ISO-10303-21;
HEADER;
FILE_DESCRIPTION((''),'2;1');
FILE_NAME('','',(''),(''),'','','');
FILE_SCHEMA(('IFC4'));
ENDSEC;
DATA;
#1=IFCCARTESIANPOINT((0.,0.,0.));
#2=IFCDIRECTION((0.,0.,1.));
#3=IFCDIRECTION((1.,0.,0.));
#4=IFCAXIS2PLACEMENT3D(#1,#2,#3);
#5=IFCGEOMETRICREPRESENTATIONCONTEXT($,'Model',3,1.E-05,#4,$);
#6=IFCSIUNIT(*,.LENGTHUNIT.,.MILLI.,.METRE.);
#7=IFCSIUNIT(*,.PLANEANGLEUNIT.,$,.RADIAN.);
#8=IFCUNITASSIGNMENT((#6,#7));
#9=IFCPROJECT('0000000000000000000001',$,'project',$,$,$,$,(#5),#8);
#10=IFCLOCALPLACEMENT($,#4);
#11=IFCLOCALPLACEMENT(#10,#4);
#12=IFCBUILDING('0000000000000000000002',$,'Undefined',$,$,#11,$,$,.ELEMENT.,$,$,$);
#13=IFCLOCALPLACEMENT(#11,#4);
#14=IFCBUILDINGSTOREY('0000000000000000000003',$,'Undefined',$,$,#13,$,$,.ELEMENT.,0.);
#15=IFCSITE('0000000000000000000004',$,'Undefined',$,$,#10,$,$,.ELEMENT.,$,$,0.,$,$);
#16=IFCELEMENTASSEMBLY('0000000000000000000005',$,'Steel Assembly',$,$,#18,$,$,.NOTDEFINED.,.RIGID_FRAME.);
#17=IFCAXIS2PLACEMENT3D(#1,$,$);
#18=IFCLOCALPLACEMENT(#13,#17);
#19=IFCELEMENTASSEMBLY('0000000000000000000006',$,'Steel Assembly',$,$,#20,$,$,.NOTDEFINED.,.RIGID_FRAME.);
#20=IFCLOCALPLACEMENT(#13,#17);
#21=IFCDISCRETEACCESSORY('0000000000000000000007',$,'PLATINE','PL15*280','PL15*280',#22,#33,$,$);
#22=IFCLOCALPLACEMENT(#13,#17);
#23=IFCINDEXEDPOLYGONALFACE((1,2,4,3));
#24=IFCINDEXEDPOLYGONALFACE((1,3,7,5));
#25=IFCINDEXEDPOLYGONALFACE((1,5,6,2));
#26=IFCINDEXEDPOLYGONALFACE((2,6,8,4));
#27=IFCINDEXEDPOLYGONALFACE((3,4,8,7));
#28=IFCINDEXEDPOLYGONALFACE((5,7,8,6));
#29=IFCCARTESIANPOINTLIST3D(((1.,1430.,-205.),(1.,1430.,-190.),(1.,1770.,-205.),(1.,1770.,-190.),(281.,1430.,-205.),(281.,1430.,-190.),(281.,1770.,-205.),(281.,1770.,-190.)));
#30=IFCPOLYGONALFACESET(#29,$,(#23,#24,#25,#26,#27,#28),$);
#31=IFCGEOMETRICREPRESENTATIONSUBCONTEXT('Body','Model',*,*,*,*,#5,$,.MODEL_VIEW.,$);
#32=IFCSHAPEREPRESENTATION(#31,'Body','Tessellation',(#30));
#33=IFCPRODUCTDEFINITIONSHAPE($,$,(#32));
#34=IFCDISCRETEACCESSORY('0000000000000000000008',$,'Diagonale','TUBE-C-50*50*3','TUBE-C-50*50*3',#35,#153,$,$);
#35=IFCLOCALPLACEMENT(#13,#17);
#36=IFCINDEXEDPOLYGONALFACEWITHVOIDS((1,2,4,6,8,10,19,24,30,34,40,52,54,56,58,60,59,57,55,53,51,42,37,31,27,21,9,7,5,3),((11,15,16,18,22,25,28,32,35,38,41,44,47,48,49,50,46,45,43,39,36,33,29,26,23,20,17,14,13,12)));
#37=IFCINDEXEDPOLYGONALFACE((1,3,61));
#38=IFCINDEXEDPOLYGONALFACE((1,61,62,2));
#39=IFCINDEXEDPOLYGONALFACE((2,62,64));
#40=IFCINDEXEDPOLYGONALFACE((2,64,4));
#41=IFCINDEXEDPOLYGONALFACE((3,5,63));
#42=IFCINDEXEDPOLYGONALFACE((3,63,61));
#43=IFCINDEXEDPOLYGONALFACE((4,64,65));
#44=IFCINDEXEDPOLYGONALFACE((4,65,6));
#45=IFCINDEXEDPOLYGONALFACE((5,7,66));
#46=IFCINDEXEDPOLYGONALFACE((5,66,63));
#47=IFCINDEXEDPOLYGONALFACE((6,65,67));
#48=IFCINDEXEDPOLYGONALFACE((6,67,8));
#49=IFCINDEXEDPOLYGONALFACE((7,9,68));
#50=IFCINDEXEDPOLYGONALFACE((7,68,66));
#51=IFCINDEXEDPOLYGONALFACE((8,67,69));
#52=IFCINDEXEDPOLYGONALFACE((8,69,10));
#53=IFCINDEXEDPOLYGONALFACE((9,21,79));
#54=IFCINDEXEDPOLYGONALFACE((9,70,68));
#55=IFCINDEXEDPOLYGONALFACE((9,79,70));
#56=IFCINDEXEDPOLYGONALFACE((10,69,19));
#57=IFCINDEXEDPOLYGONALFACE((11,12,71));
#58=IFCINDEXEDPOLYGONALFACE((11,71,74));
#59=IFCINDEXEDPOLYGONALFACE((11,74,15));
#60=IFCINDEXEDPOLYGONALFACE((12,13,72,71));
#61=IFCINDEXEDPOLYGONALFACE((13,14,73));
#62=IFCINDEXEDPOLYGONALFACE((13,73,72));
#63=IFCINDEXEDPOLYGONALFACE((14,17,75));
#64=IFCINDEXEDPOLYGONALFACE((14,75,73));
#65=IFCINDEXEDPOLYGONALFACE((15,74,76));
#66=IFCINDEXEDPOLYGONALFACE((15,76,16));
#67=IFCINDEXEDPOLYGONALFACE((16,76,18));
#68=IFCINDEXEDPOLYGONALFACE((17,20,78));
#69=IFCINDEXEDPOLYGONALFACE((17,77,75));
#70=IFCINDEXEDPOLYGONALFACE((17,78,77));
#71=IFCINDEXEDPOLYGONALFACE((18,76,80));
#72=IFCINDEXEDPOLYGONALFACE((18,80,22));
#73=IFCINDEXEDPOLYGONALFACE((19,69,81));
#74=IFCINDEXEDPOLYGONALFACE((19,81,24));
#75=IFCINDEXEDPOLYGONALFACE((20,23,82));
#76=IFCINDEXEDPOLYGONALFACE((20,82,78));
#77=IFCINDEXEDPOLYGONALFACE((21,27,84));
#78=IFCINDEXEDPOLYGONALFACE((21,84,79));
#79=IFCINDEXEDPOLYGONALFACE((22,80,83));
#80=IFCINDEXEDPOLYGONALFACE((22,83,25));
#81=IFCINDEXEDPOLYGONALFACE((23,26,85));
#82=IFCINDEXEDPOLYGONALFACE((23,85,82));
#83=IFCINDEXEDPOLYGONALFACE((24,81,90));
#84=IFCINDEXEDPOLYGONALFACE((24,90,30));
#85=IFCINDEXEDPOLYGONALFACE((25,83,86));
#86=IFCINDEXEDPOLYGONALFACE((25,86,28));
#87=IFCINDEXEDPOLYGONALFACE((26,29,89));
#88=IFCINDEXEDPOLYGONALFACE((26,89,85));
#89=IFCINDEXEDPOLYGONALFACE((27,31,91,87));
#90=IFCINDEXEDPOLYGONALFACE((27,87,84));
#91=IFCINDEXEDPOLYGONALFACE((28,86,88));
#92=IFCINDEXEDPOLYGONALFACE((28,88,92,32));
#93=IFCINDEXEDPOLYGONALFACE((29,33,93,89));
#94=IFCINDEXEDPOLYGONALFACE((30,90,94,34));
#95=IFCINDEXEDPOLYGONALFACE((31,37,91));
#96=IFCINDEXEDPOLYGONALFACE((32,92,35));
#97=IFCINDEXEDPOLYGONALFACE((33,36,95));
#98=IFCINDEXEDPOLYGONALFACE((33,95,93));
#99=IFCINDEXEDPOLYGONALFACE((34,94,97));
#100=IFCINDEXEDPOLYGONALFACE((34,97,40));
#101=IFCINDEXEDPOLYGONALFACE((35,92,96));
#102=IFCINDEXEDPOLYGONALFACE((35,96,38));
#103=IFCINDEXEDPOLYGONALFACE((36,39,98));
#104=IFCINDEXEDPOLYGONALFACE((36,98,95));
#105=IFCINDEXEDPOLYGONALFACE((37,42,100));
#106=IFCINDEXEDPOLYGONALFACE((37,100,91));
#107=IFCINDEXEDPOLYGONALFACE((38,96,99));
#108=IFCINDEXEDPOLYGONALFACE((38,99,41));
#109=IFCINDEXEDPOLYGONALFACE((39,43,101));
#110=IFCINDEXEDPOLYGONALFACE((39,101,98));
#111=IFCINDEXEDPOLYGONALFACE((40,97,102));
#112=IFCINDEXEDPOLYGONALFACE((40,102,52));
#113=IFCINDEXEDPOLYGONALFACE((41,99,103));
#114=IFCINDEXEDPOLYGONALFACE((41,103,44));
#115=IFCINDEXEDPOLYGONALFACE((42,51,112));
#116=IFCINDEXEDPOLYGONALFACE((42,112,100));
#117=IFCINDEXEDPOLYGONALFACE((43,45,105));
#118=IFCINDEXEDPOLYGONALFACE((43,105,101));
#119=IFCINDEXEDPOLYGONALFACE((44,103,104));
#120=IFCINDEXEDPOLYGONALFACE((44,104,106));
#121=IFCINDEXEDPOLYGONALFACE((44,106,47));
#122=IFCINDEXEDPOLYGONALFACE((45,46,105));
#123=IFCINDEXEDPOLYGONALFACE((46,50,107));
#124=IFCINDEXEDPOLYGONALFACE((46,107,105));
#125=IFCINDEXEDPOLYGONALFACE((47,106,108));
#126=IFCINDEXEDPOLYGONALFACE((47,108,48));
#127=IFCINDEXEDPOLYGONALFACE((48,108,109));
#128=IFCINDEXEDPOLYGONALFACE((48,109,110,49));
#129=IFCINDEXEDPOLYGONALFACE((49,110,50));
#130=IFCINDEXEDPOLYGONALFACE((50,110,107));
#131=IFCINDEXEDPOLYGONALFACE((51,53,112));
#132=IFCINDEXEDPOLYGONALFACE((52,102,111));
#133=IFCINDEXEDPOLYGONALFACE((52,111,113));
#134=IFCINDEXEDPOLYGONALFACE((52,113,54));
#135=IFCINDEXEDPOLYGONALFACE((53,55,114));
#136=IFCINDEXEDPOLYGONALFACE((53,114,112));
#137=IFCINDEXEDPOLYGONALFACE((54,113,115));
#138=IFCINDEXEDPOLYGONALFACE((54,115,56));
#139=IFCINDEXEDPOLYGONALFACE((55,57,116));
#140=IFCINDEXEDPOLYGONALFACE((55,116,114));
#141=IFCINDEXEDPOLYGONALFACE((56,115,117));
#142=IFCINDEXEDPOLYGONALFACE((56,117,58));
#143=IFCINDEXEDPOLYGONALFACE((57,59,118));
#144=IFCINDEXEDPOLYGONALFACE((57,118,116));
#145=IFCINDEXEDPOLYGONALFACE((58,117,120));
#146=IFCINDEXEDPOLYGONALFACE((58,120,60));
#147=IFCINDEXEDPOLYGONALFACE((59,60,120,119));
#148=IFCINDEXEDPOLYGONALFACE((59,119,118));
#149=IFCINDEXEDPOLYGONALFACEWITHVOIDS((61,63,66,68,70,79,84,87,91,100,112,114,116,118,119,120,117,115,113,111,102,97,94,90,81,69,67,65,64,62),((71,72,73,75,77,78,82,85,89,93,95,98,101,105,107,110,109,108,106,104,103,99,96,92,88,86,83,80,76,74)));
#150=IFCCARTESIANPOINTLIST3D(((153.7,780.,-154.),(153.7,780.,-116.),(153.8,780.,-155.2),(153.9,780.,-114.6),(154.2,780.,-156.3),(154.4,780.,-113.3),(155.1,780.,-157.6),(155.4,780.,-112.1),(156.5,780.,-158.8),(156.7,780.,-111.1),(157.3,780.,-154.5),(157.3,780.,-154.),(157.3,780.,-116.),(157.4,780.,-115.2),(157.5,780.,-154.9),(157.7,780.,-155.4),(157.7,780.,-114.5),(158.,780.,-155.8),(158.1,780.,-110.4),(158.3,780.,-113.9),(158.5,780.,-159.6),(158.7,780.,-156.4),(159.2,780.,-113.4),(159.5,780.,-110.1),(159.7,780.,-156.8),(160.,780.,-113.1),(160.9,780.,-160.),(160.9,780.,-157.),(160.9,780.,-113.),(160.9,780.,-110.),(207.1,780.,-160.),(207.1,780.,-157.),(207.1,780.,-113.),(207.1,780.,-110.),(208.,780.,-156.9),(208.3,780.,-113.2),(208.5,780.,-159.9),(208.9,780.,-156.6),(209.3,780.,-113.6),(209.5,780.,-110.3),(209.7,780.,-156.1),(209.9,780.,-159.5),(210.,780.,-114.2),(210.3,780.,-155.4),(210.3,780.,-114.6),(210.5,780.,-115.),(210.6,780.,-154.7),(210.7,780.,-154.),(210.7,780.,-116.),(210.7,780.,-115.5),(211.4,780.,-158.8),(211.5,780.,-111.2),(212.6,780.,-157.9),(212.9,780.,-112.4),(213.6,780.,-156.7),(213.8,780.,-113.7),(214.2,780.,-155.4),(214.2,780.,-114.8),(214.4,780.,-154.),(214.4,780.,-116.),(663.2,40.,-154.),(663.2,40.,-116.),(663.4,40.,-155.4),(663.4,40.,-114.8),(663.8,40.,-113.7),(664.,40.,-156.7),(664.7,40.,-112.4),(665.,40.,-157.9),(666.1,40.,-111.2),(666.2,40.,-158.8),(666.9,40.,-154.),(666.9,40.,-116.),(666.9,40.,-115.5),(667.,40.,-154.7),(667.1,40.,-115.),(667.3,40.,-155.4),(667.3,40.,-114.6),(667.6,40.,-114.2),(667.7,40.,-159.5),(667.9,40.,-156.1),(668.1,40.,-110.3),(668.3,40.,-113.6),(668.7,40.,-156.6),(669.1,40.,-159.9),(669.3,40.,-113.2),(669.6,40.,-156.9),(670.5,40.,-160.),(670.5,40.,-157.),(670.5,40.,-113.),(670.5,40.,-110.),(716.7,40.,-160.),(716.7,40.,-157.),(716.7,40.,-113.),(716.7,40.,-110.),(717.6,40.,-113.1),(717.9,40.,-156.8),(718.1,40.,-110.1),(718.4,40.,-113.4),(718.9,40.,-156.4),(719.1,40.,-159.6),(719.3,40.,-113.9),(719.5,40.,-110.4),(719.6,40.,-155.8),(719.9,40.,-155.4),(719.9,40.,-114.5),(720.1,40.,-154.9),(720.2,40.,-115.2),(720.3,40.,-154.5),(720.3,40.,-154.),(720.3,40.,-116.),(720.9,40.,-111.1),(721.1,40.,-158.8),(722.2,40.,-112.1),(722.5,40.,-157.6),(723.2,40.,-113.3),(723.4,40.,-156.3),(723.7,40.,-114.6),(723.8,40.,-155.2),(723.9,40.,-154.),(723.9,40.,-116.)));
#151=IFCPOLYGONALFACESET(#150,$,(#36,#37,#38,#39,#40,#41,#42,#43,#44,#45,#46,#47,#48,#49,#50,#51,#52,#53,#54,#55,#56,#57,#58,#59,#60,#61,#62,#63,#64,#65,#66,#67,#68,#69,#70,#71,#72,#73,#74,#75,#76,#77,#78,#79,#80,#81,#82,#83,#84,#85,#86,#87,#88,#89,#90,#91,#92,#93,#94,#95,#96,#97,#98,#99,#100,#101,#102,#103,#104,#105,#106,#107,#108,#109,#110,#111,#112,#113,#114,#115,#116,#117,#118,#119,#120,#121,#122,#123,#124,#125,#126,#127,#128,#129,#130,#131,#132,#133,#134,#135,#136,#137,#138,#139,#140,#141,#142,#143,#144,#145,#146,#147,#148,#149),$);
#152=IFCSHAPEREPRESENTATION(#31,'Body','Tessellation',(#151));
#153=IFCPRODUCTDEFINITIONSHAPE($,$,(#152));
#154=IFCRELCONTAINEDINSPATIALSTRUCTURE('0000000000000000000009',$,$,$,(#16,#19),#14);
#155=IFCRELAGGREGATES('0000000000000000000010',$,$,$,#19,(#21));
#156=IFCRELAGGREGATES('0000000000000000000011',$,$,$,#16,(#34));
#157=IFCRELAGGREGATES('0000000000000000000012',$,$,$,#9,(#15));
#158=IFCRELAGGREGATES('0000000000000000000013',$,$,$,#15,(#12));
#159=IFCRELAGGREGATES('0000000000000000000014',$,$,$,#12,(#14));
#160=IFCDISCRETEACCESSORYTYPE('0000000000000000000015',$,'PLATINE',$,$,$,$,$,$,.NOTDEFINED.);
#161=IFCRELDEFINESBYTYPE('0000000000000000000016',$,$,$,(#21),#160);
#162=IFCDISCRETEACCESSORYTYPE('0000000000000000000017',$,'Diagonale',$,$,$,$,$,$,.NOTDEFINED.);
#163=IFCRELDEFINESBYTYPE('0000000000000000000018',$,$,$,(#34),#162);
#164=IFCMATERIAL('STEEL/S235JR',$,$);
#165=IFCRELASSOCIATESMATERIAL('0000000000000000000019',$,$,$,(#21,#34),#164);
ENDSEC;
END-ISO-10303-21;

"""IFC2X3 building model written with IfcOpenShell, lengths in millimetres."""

from ifc_helpers import new_model, si_unit, frame, origin_with_axes, origin_2d_with_axis, place, context, subcontext, project, spatial, polyline, hollow_rectangle, outline, extrude, clip, halfspace, material, type_object, element, aggregate, save


model = new_model("IFC2X3")

# Units and contexts
model_context = context("Model", 3, precision=1e-05, world=origin_with_axes())
body_context = subcontext(model_context, "Body", "Model", "MODEL_VIEW")
ifc_project = project(units=[si_unit("LENGTHUNIT", "METRE", prefix="MILLI"), si_unit("PLANEANGLEUNIT", "RADIAN")], contexts=[model_context])

# Site, building, storey
site_placement = place(None, origin_with_axes())
site = spatial("IfcSite", under=ifc_project, at=site_placement, Name="Undefined", CompositionType="ELEMENT", RefElevation=0.0)
building_placement = place(site_placement, origin_with_axes())
building = spatial("IfcBuilding", under=site, at=building_placement, Name="Undefined", CompositionType="ELEMENT")
storey_placement = place(building_placement, origin_with_axes())
storey = spatial("IfcBuildingStorey", under=building, at=storey_placement, Name="Undefined", CompositionType="ELEMENT", Elevation=0.0)

# Shared definitions
ifc_material_1 = material(Name="STEEL/S235JR")

# Element assemblies
assembly_1_placement = place(storey_placement, origin_with_axes())
assembly_1 = element("IfcElementAssembly", 1, at=assembly_1_placement, inside=storey, Name="Steel Assembly", AssemblyPlace="NOTDEFINED", PredefinedType="RIGID_FRAME")
assembly_2_placement = place(storey_placement, origin_with_axes())
assembly_2 = element("IfcElementAssembly", 2, at=assembly_2_placement, inside=storey, Name="Steel Assembly", AssemblyPlace="NOTDEFINED", PredefinedType="RIGID_FRAME")

# Discrete accessory
discrete_accessory_type_1 = type_object("IfcDiscreteAccessoryType", Name="PLATINE")
discrete_accessory_1_placement = place(assembly_2_placement, frame((1.0, 1770.0, -197.5), z_axis=(0.0, 0.0, 1.0), x_axis=(0.000005, -1.0, 0.0)))
discrete_accessory_1 = element("IfcDiscreteAccessory", 3, at=discrete_accessory_1_placement, type_object=discrete_accessory_type_1, material=ifc_material_1, Name="PLATINE", Description="PL15*280", ObjectType="PL15*280", context=body_context, shape_type="SweptSolid", body=[
    extrude(outline(polyline([(0.0, 0.0), (340.0, 0.0), (340.0, 280.0), (0.0, 280.0), (0.0, 0.0)])), frame((0.0, 0.0, -7.5), z_axis=(0.0, 0.0, 1.0), x_axis=(1.0, 0.0, 0.0)), (0.0, 0.0, 1.0), 15.0),
])
aggregate(assembly_2, [discrete_accessory_1])

# Discrete accessory
discrete_accessory_type_2 = type_object("IfcDiscreteAccessoryType", Name="Diagonale")
discrete_accessory_2_placement = place(assembly_1_placement, frame((164.3, 808.6, -135.0), z_axis=(0.823606, 0.567163, 0.0), x_axis=(0.567163, -0.823606, 0.0)))
discrete_accessory_2 = element("IfcDiscreteAccessory", 4, at=discrete_accessory_2_placement, type_object=discrete_accessory_type_2, material=ifc_material_1, Name="Diagonale", Description="TUBE-C-50*50*3", ObjectType="TUBE-C-50*50*3", context=body_context, shape_type="Clipping", body=[
    clip(clip(extrude(hollow_rectangle(XDim=50.0, YDim=50.0, WallThickness=3.0, InnerFilletRadius=3.0, OuterFilletRadius=6.0, at=origin_2d_with_axis()), frame((968.0, 0.0, 0.0), z_axis=(-1.0, 0.0, 0.0), x_axis=(0.0, -1.0, 0.0)), (0.0, 0.0, 1.0), 968.0), halfspace(frame((17.5, 25.0, -25.0), z_axis=(-0.823609, 0.0, 0.567158), x_axis=(0.567158, 0.0, 0.823609)), False)), halfspace(frame((916.0, -25.0, -25.0), z_axis=(0.823609, 0.0, -0.567158), x_axis=(0.567158, 0.0, 0.823609)), False)),
])
aggregate(assembly_1, [discrete_accessory_2])

save(model, "model.ifc")
